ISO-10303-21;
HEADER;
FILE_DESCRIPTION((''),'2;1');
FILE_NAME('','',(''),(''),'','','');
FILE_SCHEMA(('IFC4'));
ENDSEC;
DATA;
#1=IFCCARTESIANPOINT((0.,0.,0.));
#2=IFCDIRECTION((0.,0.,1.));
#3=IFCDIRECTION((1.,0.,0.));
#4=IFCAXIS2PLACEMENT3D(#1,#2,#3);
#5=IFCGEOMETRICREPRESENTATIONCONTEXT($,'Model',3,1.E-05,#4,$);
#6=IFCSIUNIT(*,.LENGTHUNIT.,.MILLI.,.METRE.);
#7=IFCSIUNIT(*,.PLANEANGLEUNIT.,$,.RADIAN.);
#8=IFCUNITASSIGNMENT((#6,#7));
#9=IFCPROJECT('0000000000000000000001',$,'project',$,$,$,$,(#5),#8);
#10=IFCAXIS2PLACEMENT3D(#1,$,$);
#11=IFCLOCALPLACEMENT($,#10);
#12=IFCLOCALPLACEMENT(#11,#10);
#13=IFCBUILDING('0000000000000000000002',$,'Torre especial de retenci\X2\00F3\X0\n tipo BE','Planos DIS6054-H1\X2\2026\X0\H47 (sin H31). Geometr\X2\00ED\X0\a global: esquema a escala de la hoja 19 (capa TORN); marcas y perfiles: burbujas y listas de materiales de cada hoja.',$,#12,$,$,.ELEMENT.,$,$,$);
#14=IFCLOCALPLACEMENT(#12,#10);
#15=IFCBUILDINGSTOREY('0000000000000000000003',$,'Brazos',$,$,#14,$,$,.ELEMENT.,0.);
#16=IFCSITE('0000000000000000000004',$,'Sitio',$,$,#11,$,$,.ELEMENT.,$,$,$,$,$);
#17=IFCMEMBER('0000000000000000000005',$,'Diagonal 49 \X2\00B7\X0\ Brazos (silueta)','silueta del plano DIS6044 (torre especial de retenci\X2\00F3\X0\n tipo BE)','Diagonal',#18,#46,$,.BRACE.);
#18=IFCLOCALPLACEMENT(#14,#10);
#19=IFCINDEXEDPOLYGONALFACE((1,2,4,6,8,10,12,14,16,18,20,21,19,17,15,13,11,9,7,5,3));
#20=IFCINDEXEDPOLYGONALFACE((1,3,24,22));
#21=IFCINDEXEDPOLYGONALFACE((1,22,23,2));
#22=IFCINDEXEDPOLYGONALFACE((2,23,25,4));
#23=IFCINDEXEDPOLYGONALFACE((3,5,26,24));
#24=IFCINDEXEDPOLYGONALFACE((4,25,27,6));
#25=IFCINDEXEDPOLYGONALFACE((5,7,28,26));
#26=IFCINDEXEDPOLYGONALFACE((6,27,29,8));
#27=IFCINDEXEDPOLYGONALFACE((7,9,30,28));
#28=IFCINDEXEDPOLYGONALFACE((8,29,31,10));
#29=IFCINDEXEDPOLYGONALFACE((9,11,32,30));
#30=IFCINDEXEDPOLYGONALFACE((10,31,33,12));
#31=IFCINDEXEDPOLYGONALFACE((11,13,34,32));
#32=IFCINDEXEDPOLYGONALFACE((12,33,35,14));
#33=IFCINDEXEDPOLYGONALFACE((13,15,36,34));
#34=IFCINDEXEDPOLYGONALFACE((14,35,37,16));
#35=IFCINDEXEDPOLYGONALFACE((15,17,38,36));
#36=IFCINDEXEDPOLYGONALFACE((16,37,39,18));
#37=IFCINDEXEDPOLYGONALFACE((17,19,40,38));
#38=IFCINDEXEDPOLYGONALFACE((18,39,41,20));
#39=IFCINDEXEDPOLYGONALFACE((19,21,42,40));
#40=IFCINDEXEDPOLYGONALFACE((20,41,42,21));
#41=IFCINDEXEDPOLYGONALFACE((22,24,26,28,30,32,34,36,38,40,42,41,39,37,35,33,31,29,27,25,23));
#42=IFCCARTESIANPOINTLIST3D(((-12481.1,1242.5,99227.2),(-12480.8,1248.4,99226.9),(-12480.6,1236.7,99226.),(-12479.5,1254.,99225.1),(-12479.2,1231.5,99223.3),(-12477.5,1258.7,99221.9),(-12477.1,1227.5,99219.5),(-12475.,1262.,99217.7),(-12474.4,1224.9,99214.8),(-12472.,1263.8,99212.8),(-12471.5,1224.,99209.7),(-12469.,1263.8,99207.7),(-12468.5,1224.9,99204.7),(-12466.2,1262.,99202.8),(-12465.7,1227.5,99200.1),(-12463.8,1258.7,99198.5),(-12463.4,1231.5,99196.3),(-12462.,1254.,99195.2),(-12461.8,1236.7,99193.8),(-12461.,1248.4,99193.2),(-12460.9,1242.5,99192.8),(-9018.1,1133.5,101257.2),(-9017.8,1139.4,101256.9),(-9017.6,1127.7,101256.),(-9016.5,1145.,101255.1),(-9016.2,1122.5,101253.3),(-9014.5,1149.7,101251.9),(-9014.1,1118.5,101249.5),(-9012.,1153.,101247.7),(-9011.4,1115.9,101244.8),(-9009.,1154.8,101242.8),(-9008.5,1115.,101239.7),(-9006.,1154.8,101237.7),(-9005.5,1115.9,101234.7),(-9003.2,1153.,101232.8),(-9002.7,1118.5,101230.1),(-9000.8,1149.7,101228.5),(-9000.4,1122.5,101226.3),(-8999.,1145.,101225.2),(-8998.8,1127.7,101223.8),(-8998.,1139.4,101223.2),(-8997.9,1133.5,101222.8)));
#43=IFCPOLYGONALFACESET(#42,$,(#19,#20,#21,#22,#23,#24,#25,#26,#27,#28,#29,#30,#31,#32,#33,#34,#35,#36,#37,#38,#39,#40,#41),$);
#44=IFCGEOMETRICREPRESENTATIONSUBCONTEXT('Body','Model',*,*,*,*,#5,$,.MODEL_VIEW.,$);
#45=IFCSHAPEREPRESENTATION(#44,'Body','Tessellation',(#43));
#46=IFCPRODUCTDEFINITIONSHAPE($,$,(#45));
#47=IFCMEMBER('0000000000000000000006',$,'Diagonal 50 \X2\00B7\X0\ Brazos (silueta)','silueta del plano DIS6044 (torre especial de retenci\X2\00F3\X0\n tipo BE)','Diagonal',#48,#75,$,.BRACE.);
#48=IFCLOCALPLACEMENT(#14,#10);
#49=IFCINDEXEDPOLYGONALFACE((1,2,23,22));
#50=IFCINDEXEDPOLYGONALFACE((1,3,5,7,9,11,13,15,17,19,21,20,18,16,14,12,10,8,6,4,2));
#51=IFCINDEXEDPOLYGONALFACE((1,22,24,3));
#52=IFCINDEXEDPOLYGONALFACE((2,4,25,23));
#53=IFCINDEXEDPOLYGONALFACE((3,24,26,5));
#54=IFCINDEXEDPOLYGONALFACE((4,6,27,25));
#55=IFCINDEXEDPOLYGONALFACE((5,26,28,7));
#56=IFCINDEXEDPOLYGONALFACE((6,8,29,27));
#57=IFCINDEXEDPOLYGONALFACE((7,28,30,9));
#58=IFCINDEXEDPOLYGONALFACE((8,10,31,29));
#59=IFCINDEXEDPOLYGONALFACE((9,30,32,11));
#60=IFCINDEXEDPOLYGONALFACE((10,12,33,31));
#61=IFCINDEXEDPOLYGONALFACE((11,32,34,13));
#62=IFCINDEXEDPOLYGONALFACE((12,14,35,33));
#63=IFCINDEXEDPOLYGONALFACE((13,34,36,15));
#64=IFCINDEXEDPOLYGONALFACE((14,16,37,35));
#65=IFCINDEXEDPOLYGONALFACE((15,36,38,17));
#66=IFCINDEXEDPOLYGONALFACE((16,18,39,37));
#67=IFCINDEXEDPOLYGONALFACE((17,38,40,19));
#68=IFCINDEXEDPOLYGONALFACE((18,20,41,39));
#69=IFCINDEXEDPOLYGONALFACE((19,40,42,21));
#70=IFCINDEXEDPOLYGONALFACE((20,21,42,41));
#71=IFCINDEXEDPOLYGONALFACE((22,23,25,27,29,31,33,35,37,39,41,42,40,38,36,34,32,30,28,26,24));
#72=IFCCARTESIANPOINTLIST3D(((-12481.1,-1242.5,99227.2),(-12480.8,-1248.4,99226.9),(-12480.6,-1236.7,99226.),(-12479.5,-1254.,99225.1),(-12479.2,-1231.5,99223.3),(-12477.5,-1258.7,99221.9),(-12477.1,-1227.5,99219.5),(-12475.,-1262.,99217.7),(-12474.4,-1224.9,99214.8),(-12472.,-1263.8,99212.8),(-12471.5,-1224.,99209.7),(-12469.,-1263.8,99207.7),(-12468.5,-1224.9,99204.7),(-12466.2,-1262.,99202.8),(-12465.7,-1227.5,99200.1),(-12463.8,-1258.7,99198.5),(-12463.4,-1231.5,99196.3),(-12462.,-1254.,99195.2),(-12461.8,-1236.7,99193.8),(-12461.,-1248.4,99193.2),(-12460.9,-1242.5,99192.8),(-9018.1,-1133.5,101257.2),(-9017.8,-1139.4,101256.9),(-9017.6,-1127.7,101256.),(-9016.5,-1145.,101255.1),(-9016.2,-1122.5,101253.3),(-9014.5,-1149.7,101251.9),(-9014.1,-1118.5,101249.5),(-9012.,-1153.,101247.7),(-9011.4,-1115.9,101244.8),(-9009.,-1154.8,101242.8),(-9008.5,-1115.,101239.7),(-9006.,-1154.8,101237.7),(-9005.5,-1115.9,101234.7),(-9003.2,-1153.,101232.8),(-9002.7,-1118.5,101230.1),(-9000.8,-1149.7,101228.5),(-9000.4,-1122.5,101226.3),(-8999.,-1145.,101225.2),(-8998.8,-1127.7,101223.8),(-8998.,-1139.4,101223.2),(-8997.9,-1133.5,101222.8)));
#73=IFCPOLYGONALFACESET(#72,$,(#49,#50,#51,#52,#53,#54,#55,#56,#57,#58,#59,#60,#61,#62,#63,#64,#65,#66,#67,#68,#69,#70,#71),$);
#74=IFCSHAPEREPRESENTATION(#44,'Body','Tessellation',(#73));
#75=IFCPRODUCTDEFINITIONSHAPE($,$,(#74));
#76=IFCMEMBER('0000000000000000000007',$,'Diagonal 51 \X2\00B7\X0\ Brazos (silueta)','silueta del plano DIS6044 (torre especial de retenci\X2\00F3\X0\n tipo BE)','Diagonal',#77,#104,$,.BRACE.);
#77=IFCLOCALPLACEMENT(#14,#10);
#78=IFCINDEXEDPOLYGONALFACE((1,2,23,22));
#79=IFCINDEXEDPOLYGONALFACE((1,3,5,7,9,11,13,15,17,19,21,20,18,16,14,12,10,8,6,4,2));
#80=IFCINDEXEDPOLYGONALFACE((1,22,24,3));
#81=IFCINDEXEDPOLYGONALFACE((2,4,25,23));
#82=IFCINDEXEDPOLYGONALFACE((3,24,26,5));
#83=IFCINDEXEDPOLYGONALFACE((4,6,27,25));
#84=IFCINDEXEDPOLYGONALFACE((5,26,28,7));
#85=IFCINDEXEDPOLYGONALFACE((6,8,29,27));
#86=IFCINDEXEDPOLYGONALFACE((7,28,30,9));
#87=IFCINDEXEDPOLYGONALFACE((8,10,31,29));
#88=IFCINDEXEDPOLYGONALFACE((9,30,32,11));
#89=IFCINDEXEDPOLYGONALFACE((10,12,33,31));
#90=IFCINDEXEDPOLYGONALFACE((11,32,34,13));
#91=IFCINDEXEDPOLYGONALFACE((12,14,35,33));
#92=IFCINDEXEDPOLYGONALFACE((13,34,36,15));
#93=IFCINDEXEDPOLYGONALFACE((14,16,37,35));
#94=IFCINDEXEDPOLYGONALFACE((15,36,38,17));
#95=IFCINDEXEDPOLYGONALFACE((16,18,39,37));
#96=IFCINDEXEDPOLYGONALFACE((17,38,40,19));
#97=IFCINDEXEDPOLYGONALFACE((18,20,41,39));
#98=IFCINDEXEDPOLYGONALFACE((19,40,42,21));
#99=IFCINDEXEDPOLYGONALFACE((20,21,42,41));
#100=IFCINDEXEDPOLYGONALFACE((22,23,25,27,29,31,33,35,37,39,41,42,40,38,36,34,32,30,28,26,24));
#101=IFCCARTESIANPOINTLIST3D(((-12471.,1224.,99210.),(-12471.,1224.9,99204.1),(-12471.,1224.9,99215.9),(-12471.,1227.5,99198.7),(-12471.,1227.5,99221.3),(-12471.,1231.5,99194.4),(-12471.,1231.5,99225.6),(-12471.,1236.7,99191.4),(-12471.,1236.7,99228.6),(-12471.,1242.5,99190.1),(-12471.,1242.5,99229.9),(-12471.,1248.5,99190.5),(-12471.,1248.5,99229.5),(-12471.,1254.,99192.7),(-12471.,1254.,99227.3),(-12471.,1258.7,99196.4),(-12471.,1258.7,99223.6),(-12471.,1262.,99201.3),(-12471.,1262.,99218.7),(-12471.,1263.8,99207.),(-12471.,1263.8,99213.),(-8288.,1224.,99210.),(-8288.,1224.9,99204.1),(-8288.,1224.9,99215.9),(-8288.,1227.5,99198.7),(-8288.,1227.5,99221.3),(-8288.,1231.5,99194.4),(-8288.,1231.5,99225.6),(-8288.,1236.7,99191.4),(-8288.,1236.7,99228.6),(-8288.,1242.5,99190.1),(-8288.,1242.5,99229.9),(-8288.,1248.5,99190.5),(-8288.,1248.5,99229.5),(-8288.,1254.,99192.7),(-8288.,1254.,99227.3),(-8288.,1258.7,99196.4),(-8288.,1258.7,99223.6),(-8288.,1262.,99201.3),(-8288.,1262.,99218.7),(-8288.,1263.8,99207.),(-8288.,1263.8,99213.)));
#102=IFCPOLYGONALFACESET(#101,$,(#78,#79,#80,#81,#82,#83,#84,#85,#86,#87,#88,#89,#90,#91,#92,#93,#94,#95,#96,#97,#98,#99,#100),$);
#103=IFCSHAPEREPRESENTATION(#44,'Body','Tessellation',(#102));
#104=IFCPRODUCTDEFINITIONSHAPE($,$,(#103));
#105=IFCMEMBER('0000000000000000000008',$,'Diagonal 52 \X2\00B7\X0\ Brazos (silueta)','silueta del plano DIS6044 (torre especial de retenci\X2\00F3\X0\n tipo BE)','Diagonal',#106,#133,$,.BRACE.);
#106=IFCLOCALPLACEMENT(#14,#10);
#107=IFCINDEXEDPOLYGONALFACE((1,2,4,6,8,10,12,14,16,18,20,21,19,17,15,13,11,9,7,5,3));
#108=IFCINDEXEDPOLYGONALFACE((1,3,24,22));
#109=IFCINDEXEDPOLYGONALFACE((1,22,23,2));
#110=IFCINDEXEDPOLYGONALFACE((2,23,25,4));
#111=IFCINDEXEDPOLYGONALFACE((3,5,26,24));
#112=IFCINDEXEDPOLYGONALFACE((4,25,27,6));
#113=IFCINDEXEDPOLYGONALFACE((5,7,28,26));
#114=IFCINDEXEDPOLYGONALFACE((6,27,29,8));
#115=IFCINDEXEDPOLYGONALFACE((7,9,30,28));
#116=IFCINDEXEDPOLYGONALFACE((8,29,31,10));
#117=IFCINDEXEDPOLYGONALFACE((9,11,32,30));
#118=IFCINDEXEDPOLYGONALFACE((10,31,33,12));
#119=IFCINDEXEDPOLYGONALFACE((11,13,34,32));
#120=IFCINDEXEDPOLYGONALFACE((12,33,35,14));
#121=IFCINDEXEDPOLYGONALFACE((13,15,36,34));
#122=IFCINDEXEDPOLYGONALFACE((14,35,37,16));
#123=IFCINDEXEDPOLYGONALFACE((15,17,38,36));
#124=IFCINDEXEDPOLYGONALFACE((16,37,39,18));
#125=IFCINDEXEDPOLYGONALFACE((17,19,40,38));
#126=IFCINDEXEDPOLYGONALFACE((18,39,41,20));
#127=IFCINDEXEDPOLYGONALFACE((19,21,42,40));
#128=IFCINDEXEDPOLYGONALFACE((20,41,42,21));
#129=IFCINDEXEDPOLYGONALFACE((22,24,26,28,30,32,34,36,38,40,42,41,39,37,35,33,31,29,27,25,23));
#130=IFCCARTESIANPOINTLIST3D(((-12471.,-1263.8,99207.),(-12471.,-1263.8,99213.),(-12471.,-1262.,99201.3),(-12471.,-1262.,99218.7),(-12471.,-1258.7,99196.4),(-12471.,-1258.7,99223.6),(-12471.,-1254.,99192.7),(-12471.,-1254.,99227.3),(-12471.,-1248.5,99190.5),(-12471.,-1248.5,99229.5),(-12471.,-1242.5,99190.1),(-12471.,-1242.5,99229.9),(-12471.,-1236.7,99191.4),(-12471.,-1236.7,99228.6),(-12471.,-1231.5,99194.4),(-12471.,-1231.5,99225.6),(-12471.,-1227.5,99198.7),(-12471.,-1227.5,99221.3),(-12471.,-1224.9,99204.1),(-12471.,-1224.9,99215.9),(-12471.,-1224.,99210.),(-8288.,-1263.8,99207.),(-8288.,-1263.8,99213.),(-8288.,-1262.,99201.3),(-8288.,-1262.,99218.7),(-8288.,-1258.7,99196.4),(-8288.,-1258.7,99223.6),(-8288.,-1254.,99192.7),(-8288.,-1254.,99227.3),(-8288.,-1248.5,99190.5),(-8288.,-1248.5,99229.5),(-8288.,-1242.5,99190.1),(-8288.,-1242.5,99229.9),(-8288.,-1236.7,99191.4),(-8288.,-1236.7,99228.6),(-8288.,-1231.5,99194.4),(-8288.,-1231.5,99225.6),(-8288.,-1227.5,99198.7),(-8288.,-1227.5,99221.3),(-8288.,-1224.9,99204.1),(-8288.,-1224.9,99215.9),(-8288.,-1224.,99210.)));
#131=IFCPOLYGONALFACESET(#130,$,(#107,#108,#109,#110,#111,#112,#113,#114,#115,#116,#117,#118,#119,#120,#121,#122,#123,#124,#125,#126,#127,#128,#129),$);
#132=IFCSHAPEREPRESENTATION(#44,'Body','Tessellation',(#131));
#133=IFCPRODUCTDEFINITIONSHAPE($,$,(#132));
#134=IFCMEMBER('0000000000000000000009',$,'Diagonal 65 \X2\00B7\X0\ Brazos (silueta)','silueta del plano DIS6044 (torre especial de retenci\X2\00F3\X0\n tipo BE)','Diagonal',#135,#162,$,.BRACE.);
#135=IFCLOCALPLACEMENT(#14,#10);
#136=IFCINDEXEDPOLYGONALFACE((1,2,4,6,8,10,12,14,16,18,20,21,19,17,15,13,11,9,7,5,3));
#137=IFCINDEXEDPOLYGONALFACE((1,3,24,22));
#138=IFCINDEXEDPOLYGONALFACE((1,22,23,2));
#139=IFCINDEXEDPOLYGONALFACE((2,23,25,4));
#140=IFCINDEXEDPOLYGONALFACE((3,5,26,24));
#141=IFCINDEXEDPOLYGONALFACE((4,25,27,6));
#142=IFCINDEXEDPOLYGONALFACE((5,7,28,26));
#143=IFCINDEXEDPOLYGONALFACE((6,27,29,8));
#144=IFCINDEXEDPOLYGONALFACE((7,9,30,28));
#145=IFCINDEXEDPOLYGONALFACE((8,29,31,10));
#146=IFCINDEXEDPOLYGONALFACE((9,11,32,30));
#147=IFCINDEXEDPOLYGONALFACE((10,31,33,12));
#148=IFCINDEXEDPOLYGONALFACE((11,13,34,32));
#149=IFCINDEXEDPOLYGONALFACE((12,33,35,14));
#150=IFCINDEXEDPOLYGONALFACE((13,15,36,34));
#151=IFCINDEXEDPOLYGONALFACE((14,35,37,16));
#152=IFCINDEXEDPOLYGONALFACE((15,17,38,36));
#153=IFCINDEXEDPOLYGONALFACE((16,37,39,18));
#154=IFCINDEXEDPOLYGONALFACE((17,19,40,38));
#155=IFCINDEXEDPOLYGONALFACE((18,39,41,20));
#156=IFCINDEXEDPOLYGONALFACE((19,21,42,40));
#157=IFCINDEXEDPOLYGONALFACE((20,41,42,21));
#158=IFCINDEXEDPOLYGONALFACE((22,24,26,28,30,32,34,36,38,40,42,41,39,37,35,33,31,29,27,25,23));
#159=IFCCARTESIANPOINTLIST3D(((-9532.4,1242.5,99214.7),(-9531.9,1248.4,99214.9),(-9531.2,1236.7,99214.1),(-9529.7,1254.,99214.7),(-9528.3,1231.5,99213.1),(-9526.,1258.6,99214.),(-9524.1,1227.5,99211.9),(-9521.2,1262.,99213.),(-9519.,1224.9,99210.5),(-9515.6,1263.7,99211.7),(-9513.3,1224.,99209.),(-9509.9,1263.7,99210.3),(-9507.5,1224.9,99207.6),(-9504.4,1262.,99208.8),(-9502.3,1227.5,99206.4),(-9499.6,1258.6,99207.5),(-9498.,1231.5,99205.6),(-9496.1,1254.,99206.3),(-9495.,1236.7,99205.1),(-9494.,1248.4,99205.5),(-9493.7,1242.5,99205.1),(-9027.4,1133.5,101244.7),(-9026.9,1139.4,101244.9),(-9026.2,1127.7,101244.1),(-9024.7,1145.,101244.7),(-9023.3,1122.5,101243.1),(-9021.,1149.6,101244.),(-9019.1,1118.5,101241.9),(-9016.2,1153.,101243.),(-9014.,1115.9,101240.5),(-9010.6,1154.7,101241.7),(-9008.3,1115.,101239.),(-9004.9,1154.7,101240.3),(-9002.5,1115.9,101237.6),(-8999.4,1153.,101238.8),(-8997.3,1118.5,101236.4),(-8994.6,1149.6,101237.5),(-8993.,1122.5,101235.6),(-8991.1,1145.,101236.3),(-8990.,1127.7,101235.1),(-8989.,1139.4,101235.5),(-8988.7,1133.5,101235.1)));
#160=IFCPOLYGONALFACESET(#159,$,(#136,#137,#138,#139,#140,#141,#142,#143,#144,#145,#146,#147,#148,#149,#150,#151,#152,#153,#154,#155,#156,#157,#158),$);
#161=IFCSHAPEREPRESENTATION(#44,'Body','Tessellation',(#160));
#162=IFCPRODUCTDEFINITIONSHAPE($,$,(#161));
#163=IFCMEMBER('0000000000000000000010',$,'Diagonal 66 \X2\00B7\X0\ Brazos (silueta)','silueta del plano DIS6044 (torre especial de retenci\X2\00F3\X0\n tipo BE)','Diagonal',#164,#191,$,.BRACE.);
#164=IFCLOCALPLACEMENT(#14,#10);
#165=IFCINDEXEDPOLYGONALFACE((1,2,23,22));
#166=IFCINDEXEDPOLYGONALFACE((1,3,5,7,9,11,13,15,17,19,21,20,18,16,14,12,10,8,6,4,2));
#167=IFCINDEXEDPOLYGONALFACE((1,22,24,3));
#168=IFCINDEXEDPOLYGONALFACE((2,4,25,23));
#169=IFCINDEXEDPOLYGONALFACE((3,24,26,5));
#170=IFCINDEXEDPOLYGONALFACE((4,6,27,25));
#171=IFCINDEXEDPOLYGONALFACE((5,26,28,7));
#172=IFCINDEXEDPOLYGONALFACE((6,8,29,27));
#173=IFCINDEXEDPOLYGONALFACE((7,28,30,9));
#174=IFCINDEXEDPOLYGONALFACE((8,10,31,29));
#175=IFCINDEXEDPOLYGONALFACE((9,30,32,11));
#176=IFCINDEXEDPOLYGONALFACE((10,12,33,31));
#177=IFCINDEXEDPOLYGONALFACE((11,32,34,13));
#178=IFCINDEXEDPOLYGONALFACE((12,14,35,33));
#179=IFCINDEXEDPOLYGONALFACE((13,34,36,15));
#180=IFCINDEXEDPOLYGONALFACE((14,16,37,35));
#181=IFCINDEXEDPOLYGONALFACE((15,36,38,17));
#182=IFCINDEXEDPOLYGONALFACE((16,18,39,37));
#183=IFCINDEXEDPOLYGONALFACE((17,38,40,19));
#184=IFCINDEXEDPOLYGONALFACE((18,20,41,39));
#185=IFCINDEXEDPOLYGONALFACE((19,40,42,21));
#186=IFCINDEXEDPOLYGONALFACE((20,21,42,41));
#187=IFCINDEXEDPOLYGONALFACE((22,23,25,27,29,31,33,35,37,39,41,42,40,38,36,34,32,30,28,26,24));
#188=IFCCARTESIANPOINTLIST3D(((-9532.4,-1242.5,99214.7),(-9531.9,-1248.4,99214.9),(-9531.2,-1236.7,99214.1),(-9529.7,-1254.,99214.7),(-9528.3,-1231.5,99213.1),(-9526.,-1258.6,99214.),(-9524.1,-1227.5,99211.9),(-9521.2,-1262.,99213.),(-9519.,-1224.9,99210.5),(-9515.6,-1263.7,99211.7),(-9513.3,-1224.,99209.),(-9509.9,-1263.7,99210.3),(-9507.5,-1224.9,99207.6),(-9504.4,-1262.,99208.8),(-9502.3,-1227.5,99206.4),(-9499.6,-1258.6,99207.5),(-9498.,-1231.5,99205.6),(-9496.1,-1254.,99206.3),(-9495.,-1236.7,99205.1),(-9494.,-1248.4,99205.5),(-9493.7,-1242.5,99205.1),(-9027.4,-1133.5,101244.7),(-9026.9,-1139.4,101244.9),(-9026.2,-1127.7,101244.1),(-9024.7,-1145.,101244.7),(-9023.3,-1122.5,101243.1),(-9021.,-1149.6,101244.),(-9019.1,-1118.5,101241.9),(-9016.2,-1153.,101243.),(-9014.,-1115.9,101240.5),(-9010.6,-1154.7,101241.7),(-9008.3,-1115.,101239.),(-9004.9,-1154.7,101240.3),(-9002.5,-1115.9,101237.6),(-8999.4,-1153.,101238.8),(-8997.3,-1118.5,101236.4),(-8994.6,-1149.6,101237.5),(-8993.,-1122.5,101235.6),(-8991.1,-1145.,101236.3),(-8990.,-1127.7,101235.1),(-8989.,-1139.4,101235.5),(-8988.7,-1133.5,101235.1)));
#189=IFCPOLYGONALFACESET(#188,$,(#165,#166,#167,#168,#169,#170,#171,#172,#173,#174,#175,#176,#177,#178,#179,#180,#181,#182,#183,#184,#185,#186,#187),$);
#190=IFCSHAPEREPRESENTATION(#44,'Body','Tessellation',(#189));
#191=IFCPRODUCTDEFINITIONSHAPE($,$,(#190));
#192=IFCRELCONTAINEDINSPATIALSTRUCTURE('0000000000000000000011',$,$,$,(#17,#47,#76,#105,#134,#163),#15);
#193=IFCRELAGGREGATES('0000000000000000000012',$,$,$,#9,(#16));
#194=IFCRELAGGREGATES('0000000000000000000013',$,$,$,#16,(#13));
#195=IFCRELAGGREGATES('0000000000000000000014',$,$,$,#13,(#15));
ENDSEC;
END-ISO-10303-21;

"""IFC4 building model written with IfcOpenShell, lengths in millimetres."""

from ifc_helpers import new_model, si_unit, frame, origin, origin_with_axes, place, context, subcontext, project, spatial, circle, extrude, element, save


model = new_model("IFC4")

# Units and contexts
model_context = context("Model", 3, precision=1e-05, world=origin_with_axes())
body_context = subcontext(model_context, "Body", "Model", "MODEL_VIEW")
ifc_project = project(units=[si_unit("LENGTHUNIT", "METRE", prefix="MILLI"), si_unit("PLANEANGLEUNIT", "RADIAN")], contexts=[model_context])

# Site, building, storey
site_placement = place(None, origin())
site = spatial("IfcSite", under=ifc_project, at=site_placement, Name="Sitio", CompositionType="ELEMENT")
building_placement = place(site_placement, origin())
building = spatial("IfcBuilding", under=site, at=building_placement, Name="Torre especial de retención tipo BE", Description="Planos DIS6054-H1…H47 (sin H31). Geometría global: esquema a escala de la hoja 19 (capa TORN); marcas y perfiles: burbujas y listas de materiales de cada hoja.", CompositionType="ELEMENT")
storey_placement = place(building_placement, origin())
storey = spatial("IfcBuildingStorey", under=building, at=storey_placement, Name="Brazos", CompositionType="ELEMENT", Elevation=0.0)

# Members
for number, where, z_axis, x_axis, name in (
    (1, (-12471.0, 1244.0, 99210.0), (0.862384, -0.027144, 0.505527), (-0.023417, -0.999632, -0.013727), "Diagonal 49 · Brazos (silueta)"),
    (2, (-12471.0, -1244.0, 99210.0), (0.862384, 0.027144, 0.505527), (-0.023417, 0.999632, -0.013727), "Diagonal 50 · Brazos (silueta)"),
):
    element("IfcMember", number, at=place(storey_placement, frame(where, z_axis=z_axis, x_axis=x_axis)), inside=storey, Name=name, Description="silueta del plano DIS6044 (torre especial de retención tipo BE)", ObjectType="Diagonal", PredefinedType="BRACE", context=body_context, shape_type="SweptSolid", body=[
        extrude(circle(Radius=20.0), None, (0.0, 0.0, 1.0), 4015.6),
    ])
for number, where, z_axis, x_axis, name in (
    (3, (-8288.0, 1244.0, 99210.0), (-1.0, 0.0, 0.0), (0.0, -1.0, 0.0), "Diagonal 51 · Brazos (silueta)"),
    (4, (-8288.0, -1244.0, 99210.0), (-1.0, 0.0, 0.0), (0.0, 1.0, 0.0), "Diagonal 52 · Brazos (silueta)"),
):
    element("IfcMember", number, at=place(storey_placement, frame(where, z_axis=z_axis, x_axis=x_axis)), inside=storey, Name=name, Description="silueta del plano DIS6044 (torre especial de retención tipo BE)", ObjectType="Diagonal", PredefinedType="BRACE", context=body_context, shape_type="SweptSolid", body=[
        extrude(circle(Radius=20.0), None, (0.0, 0.0, 1.0), 4183.0),
    ])
for number, where, z_axis, x_axis, name in (
    (5, (-9008.0, 1135.0, 101240.0), (-0.241084, 0.052036, -0.969108), (-0.012562, -0.998645, -0.050497), "Diagonal 65 · Brazos (silueta)"),
    (6, (-9008.0, -1135.0, 101240.0), (-0.241084, -0.052036, -0.969108), (-0.012562, 0.998645, -0.050497), "Diagonal 66 · Brazos (silueta)"),
):
    element("IfcMember", number, at=place(storey_placement, frame(where, z_axis=z_axis, x_axis=x_axis)), inside=storey, Name=name, Description="silueta del plano DIS6044 (torre especial de retención tipo BE)", ObjectType="Diagonal", PredefinedType="BRACE", context=body_context, shape_type="SweptSolid", body=[
        extrude(circle(Radius=20.0), None, (0.0, 0.0, 1.0), 2094.7),
    ])

save(model, "model.ifc")
